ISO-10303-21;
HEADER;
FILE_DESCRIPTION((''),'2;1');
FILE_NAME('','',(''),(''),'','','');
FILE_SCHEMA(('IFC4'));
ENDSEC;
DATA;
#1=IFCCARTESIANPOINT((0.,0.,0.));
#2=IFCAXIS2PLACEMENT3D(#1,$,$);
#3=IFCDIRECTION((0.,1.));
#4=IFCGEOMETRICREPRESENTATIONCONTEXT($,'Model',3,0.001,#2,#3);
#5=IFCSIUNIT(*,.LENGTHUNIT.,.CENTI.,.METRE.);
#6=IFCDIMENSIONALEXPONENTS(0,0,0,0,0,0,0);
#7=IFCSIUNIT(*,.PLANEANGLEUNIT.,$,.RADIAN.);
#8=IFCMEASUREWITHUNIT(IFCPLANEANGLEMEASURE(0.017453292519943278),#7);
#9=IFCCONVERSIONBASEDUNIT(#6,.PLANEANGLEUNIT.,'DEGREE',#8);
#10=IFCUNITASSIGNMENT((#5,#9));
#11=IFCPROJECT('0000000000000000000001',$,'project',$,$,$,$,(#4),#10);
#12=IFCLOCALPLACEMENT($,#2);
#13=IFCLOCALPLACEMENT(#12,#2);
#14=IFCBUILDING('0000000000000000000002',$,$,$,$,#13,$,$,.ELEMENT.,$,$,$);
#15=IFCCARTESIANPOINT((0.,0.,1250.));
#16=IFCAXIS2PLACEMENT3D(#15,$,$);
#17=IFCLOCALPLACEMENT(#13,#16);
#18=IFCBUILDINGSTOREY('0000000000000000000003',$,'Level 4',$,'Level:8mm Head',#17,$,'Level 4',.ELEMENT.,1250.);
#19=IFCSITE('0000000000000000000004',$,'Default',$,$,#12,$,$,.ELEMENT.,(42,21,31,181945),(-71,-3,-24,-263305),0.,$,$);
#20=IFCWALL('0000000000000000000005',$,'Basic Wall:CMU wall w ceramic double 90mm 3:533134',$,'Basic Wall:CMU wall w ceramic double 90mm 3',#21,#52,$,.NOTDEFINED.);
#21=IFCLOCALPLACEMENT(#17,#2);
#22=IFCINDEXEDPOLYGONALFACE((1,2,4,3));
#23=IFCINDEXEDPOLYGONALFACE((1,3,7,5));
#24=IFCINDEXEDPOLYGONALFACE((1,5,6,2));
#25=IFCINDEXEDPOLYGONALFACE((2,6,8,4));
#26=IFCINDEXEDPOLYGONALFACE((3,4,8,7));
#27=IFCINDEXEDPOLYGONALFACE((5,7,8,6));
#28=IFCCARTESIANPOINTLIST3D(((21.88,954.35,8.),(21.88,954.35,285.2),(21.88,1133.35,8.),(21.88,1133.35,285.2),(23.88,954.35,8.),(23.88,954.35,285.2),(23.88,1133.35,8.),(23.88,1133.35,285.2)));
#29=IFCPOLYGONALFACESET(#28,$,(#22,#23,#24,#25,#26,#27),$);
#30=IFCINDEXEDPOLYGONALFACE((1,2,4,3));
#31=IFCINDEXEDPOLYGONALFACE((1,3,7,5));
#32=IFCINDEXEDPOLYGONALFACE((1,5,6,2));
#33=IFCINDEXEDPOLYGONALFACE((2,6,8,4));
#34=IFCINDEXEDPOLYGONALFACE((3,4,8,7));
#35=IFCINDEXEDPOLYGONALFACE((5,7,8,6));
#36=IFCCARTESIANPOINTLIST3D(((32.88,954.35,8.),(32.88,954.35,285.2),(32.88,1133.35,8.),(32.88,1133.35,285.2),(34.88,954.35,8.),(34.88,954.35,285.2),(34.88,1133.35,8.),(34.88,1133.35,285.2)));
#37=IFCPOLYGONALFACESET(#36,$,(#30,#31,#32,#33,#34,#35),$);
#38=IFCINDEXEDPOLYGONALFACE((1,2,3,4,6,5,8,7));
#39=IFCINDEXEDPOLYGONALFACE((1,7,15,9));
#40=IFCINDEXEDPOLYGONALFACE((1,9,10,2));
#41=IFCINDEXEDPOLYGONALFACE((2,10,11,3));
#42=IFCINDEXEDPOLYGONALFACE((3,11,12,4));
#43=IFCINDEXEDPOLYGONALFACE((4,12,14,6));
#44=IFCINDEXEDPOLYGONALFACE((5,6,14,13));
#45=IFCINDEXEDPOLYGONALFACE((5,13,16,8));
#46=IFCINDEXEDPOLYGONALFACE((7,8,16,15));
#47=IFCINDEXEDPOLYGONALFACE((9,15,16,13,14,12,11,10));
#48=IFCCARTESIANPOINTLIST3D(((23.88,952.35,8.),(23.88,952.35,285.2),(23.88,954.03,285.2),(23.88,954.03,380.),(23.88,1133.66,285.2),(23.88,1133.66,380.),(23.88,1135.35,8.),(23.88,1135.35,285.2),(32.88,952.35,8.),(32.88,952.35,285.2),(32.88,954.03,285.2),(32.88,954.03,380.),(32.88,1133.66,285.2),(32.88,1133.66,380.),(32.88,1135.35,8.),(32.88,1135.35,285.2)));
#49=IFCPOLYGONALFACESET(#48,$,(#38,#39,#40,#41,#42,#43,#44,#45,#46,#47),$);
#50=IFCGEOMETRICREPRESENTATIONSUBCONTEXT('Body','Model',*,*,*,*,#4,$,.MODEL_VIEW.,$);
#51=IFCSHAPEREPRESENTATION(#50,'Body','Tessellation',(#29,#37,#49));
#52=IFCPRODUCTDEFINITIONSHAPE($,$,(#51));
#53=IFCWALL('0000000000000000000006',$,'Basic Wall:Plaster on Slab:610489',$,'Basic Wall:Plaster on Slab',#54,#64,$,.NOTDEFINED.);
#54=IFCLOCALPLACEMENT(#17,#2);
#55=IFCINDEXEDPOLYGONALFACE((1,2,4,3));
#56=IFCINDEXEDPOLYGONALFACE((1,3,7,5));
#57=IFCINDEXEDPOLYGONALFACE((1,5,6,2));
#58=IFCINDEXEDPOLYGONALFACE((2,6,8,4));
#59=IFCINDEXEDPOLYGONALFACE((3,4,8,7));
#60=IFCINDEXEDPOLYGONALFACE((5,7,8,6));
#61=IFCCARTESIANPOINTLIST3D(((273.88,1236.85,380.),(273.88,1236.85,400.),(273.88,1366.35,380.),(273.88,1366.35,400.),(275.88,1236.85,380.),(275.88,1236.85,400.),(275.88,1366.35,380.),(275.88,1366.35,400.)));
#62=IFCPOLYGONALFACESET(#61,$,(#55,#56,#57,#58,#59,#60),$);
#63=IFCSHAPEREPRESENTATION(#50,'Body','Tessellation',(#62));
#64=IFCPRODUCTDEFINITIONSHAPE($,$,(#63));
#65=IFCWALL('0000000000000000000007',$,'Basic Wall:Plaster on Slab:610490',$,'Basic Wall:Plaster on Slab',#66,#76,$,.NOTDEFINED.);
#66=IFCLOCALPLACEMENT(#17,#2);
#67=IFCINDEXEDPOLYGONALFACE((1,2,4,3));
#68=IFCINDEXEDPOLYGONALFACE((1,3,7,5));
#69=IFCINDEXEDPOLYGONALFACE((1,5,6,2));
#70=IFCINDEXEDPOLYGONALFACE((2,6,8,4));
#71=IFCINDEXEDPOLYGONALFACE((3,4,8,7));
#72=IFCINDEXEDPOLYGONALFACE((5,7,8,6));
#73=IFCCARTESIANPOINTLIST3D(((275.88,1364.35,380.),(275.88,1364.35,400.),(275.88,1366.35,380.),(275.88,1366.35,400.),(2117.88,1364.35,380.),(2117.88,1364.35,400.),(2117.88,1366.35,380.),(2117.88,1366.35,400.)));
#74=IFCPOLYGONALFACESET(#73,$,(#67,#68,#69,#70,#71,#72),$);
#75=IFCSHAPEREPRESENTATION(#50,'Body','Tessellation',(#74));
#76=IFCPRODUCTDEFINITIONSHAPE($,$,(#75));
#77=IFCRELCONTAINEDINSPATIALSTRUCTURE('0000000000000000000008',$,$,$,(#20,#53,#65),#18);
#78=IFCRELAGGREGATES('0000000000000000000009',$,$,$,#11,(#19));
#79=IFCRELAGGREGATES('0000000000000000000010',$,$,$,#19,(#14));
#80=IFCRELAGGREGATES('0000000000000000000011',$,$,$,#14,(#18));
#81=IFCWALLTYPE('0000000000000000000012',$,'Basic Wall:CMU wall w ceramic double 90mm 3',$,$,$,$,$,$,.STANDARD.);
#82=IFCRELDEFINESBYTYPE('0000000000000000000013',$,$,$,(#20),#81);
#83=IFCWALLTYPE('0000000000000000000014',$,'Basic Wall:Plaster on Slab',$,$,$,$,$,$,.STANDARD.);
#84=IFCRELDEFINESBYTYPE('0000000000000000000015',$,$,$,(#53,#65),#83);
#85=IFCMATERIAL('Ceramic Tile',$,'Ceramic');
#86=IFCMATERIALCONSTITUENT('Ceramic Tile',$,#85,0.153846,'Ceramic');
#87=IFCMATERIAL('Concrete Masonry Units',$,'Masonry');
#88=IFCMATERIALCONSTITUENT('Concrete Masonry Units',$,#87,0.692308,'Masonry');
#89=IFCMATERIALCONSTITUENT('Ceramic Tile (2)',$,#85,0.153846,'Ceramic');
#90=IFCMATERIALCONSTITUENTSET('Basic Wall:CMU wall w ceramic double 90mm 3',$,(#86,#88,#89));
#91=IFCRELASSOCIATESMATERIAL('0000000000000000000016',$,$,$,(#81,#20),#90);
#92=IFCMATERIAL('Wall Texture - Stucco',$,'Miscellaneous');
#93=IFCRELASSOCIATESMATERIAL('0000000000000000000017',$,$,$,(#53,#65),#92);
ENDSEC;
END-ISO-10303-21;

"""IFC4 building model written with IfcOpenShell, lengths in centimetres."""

from ifc_helpers import new_model, entity, si_unit, converted_unit, direction, frame, origin, place, context, subcontext, project, spatial, indexed_curve, outline, extrude, material, constituent, constituent_set, type_object, element, save


model = new_model("IFC4")

# Units and contexts
model_context = context("Model", 3, precision=0.001, world=origin(), true_north=direction((0.0, 1.0)))
body_context = subcontext(model_context, "Body", "Model", "MODEL_VIEW")
ifc_project = project(units=[si_unit("LENGTHUNIT", "METRE", prefix="CENTI"), converted_unit("PLANEANGLEUNIT", "DEGREE", entity("IfcPlaneAngleMeasure", 0.017453292519943278), si_unit("PLANEANGLEUNIT", "RADIAN"), dimensions=[0, 0, 0, 0, 0, 0, 0])], contexts=[model_context])

# Site, building, storey
site_placement = place(None, origin())
site = spatial("IfcSite", under=ifc_project, at=site_placement, Name="Default", CompositionType="ELEMENT", RefLatitude=(42, 21, 31, 181945), RefLongitude=(-71, -3, -24, -263305), RefElevation=0.0)
building_placement = place(site_placement, origin())
building = spatial("IfcBuilding", under=site, at=building_placement, CompositionType="ELEMENT")
storey_placement = place(building_placement, frame((0.0, 0.0, 1250.0)))
storey = spatial("IfcBuildingStorey", under=building, at=storey_placement, Name="Level 4", ObjectType="Level:8mm Head", LongName="Level 4", CompositionType="ELEMENT", Elevation=1250.0)

# Shared definitions
ifc_material_1 = material(Name="Wall Texture - Stucco", Category="Miscellaneous")
ifc_material_2 = material(Name="Concrete Masonry Units", Category="Masonry")

# Walls
ifc_material_3 = material(Name="Ceramic Tile", Category="Ceramic")
ifc_constituent_1 = constituent(ifc_material_3, Name="Ceramic Tile", Category="Ceramic", fraction=0.153846)
ifc_constituent_2 = constituent(ifc_material_2, Name="Concrete Masonry Units", Category="Masonry", fraction=0.692308)
ifc_constituent_3 = constituent(ifc_material_3, Name="Ceramic Tile (2)", Category="Ceramic", fraction=0.153846)
ifc_constituent_set_1 = constituent_set(constituents=[ifc_constituent_1, ifc_constituent_2, ifc_constituent_3], Name="Basic Wall:CMU wall w ceramic double 90mm 3")
wall_type_1 = type_object("IfcWallType", Name="Basic Wall:CMU wall w ceramic double 90mm 3", PredefinedType="STANDARD", material=ifc_constituent_set_1)
wall_1_placement = place(storey_placement, frame((28.38, 1133.35, 8.0), z_axis=(0.0, 0.0, 1.0), x_axis=(0.0, -1.0, 0.0)))
element("IfcWall", 1, at=wall_1_placement, inside=storey, type_object=wall_type_1, material=ifc_constituent_set_1, Name="Basic Wall:CMU wall w ceramic double 90mm 3:533134", ObjectType="Basic Wall:CMU wall w ceramic double 90mm 3", PredefinedType="NOTDEFINED", context=body_context, shape_type="SweptSolid", body=[
    extrude(outline(indexed_curve([(-1.0, -89.5), (1.0, -89.5), (1.0, 89.5), (-1.0, 89.5), (-1.0, -89.5)], self_intersect=False)), frame((89.5, -5.5, 0.0), z_axis=(0.0, 0.0, 1.0), x_axis=(0.0, 1.0, 0.0)), (0.0, 0.0, 1.0), 277.2),
    extrude(outline(indexed_curve([(-1.0, -89.5), (1.0, -89.5), (1.0, 89.5), (-1.0, 89.5), (-1.0, -89.5)], self_intersect=False)), frame((89.5, 5.5, 0.0), z_axis=(0.0, 0.0, 1.0), x_axis=(0.0, -1.0, 0.0)), (0.0, 0.0, 1.0), 277.2),
    extrude(outline(indexed_curve([(-231.6, -91.5), (45.6, -91.5), (45.6, -89.82), (140.4, -89.82), (140.4, 89.82), (45.6, 89.82), (45.6, 91.5), (-231.6, 91.5), (-231.6, -91.5)], self_intersect=False)), frame((89.5, -4.5, 231.6), z_axis=(0.0, 1.0, 0.0), x_axis=(0.0, 0.0, 1.0)), (0.0, 0.0, 1.0), 9.0),
])
wall_type_2 = type_object("IfcWallType", Name="Basic Wall:Plaster on Slab", PredefinedType="STANDARD")
wall_2_placement = place(storey_placement, frame((274.88, 1236.85, 380.0), z_axis=(0.0, 0.0, 1.0), x_axis=(0.0, 1.0, 0.0)))
element("IfcWall", 2, at=wall_2_placement, inside=storey, type_object=wall_type_2, material=ifc_material_1, Name="Basic Wall:Plaster on Slab:610489", ObjectType="Basic Wall:Plaster on Slab", PredefinedType="NOTDEFINED", context=body_context, shape_type="SweptSolid", body=[
    extrude(outline(indexed_curve([(129.5, 1.0), (0.0, 1.0), (0.0, -1.0), (129.5, -1.0), (129.5, 1.0)], self_intersect=False)), origin(), (0.0, 0.0, 1.0), 20.0),
])
wall_3_placement = place(storey_placement, frame((275.88, 1365.35, 380.0)))
element("IfcWall", 3, at=wall_3_placement, inside=storey, type_object=wall_type_2, material=ifc_material_1, Name="Basic Wall:Plaster on Slab:610490", ObjectType="Basic Wall:Plaster on Slab", PredefinedType="NOTDEFINED", context=body_context, shape_type="SweptSolid", body=[
    extrude(outline(indexed_curve([(1842.0, 1.0), (0.0, 1.0), (0.0, -1.0), (1842.0, -1.0), (1842.0, 1.0)], self_intersect=False)), origin(), (0.0, 0.0, 1.0), 20.0),
])

save(model, "model.ifc")
